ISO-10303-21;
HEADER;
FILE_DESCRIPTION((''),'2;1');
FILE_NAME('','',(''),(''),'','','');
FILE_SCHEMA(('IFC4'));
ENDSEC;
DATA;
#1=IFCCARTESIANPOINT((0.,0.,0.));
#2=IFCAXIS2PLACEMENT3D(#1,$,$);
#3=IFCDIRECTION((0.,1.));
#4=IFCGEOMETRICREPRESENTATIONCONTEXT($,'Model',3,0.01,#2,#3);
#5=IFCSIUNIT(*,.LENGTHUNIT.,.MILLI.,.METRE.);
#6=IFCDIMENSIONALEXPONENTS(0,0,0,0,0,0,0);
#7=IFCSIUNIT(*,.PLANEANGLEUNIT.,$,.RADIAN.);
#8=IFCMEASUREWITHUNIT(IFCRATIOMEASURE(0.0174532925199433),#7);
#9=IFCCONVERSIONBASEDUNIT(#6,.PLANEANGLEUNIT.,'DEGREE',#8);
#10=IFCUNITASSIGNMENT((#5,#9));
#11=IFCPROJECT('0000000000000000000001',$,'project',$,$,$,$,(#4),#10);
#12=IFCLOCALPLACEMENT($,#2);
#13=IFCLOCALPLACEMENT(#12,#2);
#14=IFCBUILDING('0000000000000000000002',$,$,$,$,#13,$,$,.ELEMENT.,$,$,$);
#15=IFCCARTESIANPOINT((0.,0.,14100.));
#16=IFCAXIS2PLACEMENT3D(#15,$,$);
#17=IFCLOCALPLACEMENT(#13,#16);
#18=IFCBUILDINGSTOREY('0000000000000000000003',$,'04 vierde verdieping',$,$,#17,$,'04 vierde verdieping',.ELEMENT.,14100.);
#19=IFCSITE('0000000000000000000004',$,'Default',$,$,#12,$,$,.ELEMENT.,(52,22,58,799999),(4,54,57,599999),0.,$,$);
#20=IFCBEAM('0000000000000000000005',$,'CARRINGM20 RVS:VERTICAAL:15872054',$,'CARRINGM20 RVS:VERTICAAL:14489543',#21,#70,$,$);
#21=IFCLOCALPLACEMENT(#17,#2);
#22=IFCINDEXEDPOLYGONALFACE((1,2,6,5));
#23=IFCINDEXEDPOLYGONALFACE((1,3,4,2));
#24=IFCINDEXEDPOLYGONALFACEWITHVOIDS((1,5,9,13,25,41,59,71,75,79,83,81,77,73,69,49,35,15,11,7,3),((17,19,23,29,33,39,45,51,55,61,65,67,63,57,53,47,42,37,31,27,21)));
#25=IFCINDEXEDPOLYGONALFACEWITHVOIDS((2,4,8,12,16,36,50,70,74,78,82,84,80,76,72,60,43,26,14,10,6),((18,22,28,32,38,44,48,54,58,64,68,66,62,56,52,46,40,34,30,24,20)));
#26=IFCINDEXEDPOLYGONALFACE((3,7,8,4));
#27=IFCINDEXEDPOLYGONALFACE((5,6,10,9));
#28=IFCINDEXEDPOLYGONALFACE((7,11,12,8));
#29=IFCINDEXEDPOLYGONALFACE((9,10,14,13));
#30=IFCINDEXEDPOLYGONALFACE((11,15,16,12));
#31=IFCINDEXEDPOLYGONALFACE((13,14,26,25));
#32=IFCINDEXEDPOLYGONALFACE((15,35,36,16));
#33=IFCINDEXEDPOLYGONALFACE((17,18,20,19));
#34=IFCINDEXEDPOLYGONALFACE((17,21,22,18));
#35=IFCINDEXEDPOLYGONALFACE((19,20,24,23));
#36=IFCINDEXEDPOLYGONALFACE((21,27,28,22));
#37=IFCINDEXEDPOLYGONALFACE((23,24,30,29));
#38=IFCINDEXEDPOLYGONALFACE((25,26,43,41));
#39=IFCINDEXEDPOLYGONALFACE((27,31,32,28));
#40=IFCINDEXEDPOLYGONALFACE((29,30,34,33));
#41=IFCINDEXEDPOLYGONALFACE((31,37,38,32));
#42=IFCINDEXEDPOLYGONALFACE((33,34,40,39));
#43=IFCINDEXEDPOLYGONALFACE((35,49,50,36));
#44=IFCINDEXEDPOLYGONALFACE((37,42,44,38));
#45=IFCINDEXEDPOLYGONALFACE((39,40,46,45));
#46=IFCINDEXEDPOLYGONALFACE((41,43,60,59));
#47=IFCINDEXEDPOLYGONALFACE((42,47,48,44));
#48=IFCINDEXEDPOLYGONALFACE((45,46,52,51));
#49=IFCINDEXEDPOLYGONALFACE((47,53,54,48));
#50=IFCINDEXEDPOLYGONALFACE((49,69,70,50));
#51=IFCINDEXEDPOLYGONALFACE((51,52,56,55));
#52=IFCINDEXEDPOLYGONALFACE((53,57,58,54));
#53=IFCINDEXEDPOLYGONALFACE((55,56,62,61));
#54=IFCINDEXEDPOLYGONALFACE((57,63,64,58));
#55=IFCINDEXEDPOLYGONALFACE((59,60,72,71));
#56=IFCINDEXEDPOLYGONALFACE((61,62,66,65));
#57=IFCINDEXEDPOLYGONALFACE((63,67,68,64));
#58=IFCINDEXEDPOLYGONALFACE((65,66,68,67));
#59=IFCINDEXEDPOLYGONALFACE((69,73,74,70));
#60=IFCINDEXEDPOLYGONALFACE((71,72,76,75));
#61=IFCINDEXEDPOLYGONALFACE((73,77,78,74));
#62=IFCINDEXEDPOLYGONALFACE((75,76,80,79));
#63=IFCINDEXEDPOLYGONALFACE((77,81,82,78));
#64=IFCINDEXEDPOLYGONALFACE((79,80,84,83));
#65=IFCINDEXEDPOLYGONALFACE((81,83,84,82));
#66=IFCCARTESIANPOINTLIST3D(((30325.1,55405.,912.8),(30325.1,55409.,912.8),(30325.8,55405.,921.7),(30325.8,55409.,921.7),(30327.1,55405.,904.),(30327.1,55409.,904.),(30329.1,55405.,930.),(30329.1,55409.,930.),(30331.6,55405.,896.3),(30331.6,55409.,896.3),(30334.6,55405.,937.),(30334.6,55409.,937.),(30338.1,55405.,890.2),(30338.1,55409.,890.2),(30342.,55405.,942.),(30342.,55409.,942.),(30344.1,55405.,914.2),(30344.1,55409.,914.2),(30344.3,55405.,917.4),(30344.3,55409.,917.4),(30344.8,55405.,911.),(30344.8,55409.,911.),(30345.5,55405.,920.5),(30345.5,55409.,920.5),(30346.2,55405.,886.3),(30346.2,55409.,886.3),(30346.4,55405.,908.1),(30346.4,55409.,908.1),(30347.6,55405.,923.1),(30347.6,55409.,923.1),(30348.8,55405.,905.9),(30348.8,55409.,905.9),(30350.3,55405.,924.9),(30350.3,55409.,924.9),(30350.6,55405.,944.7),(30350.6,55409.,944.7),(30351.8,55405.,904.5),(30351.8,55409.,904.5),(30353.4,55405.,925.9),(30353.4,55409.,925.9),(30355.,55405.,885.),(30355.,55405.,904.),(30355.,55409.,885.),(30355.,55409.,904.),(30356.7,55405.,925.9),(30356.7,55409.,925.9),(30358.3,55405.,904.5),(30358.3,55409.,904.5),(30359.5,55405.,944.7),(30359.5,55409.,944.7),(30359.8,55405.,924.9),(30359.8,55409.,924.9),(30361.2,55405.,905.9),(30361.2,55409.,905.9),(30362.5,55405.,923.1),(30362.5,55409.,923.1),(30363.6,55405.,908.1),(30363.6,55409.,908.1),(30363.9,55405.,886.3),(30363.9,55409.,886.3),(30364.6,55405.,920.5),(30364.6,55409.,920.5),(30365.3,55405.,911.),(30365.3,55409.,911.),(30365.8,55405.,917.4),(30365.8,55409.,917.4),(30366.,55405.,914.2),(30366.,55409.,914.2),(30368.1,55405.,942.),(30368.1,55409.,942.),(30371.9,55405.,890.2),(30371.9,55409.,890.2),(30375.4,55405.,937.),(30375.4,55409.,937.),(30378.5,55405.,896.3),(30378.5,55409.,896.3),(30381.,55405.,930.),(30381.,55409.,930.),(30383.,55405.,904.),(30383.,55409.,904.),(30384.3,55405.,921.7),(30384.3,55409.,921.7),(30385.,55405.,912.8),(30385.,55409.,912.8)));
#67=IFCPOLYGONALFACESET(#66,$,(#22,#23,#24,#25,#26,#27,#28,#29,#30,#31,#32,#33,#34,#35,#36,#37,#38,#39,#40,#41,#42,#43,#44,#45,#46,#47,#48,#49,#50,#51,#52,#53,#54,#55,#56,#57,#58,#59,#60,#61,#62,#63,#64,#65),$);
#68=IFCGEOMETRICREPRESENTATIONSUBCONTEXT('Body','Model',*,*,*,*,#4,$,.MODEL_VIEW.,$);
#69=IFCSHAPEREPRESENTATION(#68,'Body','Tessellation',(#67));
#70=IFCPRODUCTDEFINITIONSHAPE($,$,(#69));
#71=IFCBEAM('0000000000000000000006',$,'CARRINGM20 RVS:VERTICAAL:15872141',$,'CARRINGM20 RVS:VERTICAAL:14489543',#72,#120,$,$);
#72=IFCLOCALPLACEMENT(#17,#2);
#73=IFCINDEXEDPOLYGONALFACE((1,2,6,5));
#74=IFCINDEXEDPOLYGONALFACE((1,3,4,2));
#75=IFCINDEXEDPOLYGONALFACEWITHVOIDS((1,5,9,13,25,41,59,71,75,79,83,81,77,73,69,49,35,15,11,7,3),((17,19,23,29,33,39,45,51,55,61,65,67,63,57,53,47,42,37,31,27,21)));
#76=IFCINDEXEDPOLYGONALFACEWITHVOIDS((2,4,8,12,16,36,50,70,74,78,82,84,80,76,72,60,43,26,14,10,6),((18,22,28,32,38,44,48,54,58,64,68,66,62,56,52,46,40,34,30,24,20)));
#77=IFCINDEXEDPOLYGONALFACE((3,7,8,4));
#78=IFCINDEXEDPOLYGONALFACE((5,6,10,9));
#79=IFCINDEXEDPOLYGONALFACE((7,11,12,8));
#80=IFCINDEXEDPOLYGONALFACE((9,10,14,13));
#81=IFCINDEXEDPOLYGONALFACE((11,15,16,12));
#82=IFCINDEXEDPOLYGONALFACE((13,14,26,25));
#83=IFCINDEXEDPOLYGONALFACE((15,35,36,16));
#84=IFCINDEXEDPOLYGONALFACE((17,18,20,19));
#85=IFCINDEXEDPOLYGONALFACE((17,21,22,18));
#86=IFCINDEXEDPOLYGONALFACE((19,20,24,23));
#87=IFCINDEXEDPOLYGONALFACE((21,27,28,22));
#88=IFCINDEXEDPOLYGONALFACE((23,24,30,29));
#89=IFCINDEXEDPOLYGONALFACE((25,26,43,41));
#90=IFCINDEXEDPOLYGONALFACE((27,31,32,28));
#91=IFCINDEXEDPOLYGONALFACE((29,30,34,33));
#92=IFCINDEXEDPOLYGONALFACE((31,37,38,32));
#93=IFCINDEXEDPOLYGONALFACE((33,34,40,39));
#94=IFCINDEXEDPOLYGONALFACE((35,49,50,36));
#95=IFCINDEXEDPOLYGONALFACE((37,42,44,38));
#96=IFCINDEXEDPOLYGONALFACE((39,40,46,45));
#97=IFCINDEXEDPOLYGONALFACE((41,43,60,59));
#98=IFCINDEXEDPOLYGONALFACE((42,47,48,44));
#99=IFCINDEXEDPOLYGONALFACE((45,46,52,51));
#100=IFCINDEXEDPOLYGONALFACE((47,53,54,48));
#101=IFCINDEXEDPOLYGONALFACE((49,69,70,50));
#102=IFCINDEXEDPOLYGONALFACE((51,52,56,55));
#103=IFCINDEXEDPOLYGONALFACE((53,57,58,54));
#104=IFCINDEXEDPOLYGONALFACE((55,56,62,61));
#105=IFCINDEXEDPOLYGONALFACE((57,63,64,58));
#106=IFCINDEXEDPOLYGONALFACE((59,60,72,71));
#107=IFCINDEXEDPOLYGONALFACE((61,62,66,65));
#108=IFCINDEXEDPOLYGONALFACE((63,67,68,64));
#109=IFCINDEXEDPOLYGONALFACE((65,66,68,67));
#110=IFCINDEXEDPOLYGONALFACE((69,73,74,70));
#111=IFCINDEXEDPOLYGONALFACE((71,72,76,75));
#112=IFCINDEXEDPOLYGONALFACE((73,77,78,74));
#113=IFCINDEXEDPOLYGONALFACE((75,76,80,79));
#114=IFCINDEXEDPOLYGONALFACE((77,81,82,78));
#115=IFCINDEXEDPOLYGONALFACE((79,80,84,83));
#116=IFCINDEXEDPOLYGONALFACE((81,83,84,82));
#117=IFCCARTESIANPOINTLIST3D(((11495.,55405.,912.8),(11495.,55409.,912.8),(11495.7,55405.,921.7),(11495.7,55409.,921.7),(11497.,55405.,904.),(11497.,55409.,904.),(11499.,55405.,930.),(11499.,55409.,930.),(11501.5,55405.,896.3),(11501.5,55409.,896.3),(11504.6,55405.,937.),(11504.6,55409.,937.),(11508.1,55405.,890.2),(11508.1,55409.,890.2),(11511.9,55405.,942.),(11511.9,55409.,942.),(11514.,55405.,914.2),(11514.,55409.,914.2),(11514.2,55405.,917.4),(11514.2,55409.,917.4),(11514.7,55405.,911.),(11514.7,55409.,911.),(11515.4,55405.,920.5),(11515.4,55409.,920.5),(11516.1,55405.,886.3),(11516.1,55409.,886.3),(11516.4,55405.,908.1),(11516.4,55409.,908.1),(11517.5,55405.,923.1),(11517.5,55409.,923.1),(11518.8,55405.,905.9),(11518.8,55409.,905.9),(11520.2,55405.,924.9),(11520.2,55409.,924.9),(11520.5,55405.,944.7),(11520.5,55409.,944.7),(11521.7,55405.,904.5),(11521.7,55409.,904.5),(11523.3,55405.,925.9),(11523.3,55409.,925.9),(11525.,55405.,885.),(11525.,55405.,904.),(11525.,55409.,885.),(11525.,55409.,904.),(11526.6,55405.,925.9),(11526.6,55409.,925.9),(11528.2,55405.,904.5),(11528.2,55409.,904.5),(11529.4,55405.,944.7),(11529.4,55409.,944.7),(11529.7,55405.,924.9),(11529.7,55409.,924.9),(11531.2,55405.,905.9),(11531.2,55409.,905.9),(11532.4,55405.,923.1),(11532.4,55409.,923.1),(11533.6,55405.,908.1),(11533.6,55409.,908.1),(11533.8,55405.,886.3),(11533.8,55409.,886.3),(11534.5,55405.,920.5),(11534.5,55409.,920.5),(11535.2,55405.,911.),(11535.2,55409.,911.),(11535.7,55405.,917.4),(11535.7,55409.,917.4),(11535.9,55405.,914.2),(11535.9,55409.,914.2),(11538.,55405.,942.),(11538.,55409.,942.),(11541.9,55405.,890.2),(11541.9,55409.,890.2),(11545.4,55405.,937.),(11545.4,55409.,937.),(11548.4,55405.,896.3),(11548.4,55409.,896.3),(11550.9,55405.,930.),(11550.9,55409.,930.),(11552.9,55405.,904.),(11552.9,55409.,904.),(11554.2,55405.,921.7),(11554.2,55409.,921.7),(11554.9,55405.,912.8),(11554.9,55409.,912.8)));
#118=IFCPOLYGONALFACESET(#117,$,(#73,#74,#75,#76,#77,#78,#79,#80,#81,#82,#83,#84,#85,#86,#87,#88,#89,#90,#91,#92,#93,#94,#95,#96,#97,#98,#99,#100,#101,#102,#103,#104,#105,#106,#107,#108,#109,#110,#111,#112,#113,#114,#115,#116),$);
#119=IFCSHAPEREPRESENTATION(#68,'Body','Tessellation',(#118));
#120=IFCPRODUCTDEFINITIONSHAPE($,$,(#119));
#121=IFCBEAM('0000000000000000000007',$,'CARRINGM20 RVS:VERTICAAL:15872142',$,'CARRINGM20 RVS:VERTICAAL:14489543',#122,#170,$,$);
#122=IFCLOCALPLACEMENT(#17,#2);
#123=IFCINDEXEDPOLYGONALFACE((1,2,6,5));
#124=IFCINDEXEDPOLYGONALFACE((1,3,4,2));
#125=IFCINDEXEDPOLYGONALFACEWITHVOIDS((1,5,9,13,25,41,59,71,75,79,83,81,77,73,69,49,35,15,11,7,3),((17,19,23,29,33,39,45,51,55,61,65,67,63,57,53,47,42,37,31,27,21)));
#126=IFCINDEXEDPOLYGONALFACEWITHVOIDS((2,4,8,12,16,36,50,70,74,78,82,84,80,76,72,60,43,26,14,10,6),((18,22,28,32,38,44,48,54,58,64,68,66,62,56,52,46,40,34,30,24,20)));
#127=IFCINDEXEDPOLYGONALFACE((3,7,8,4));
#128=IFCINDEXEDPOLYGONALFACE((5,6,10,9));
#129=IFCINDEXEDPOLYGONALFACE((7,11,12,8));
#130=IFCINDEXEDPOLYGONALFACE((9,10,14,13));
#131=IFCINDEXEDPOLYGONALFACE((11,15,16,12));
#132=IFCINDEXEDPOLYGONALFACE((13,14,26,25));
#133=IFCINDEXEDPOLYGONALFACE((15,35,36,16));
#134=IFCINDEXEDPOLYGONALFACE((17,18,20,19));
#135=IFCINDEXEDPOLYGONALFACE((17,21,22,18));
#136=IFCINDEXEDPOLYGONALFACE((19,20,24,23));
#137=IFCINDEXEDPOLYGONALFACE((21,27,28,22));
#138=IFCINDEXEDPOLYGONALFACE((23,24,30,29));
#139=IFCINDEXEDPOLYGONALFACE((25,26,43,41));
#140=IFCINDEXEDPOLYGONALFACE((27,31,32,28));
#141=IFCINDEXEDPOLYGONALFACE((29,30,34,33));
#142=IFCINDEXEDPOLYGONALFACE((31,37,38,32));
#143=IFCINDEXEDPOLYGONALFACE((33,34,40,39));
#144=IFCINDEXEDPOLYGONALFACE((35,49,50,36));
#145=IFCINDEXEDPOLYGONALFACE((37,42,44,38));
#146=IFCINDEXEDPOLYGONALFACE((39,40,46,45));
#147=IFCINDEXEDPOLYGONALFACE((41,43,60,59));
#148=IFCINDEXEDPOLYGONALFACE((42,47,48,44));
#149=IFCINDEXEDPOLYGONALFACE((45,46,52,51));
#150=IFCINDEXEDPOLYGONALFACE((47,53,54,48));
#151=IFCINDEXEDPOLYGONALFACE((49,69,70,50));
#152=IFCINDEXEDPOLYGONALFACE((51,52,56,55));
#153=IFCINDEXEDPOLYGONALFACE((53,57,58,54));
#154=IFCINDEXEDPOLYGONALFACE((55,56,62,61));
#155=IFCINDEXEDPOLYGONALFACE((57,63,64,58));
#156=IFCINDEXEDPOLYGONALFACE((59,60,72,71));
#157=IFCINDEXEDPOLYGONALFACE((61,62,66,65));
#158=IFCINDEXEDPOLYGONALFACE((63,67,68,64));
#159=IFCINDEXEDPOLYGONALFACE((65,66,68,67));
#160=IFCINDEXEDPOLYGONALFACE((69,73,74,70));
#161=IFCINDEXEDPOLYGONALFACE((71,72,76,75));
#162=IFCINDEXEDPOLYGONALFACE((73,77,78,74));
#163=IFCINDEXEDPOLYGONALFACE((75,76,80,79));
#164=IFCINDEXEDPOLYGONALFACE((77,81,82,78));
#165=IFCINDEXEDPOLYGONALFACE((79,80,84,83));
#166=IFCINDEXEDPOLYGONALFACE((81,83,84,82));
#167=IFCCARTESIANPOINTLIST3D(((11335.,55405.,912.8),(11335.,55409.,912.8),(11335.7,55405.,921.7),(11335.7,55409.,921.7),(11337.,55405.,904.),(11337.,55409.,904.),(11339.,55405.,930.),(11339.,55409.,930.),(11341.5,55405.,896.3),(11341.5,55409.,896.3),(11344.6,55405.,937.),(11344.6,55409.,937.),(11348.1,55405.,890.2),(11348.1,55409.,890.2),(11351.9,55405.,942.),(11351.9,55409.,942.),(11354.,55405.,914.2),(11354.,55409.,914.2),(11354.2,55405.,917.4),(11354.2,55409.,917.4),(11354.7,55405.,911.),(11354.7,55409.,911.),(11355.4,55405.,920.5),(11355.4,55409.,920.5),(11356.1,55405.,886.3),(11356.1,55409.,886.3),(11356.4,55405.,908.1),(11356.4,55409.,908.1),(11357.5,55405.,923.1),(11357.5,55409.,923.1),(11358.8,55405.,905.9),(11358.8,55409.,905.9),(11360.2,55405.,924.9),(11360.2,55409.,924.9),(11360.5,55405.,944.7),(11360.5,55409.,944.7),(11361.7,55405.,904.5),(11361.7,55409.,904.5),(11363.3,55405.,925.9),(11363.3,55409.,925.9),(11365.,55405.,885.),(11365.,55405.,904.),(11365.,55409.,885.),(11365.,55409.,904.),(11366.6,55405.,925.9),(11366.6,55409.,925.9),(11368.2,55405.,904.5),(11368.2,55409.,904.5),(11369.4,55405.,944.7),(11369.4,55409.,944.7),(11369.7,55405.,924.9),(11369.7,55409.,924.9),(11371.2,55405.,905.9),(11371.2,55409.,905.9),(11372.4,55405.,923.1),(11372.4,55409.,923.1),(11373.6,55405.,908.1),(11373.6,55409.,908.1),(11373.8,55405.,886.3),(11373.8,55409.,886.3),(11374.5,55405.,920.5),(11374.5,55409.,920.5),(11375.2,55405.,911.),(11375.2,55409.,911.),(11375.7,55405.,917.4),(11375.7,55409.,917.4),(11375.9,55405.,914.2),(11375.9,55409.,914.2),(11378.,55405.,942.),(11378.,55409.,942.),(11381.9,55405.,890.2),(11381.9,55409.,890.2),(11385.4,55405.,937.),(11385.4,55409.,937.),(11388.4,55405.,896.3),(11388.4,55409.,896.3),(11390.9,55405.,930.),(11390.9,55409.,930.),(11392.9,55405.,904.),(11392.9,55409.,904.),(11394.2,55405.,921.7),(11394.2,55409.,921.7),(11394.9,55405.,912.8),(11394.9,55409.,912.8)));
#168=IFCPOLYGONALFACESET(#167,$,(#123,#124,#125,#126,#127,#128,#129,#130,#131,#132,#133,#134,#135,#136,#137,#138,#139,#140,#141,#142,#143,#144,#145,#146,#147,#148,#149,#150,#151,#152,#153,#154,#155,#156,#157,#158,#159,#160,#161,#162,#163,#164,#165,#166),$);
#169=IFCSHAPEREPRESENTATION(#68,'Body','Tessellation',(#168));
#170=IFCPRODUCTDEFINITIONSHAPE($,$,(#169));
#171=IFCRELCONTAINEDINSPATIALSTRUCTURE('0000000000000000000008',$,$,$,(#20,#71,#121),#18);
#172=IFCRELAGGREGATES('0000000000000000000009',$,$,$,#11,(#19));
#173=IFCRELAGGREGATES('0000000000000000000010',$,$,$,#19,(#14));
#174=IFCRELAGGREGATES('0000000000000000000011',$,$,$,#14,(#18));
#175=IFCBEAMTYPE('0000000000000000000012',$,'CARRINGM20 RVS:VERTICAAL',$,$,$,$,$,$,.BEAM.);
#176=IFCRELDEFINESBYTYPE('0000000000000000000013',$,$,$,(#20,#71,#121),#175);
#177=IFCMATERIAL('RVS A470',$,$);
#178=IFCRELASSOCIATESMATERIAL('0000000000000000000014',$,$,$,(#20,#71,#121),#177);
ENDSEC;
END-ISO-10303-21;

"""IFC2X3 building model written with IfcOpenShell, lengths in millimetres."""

from ifc_helpers import new_model, entity, si_unit, converted_unit, direction, frame, origin, origin_2d_with_axis, place, context, subcontext, project, spatial, hollow_circle, extrude, material, type_object, element, save


model = new_model("IFC2X3")

# Units and contexts
model_context = context("Model", 3, precision=0.01, world=origin(), true_north=direction((0.0, 1.0)))
body_context = subcontext(model_context, "Body", "Model", "MODEL_VIEW")
ifc_project = project(units=[si_unit("LENGTHUNIT", "METRE", prefix="MILLI"), converted_unit("PLANEANGLEUNIT", "DEGREE", entity("IfcRatioMeasure", 0.0174532925199433), si_unit("PLANEANGLEUNIT", "RADIAN"), dimensions=[0, 0, 0, 0, 0, 0, 0])], contexts=[model_context])

# Site, building, storey
site_placement = place(None, origin())
site = spatial("IfcSite", under=ifc_project, at=site_placement, Name="Default", CompositionType="ELEMENT", RefLatitude=(52, 22, 58, 799999), RefLongitude=(4, 54, 57, 599999), RefElevation=0.0)
building_placement = place(site_placement, origin())
building = spatial("IfcBuilding", under=site, at=building_placement, CompositionType="ELEMENT")
storey_placement = place(building_placement, frame((0.0, 0.0, 14100.0)))
storey = spatial("IfcBuildingStorey", under=building, at=storey_placement, Name="04 vierde verdieping", LongName="04 vierde verdieping", CompositionType="ELEMENT", Elevation=14100.0)

# Beams
ifc_material_1 = material(Name="RVS A470")
beam_type_1 = type_object("IfcBeamType", Name="CARRINGM20 RVS:VERTICAAL", PredefinedType="BEAM")
beam_1_placement = place(storey_placement, origin())
element("IfcBeam", 1, at=beam_1_placement, inside=storey, type_object=beam_type_1, material=ifc_material_1, Name="CARRINGM20 RVS:VERTICAAL:15872054", ObjectType="CARRINGM20 RVS:VERTICAAL:14489543", context=body_context, shape_type="SweptSolid", body=[
    extrude(hollow_circle(Radius=30.0, WallThickness=19.0, at=origin_2d_with_axis()), frame((30355.0, 55405.0, 915.0), z_axis=(0.0, 1.0, 0.0), x_axis=(0.0, 0.0, -1.0)), (0.0, 0.0, 1.0), 4.0),
])
beam_2_placement = place(storey_placement, origin())
element("IfcBeam", 2, at=beam_2_placement, inside=storey, type_object=beam_type_1, material=ifc_material_1, Name="CARRINGM20 RVS:VERTICAAL:15872141", ObjectType="CARRINGM20 RVS:VERTICAAL:14489543", context=body_context, shape_type="SweptSolid", body=[
    extrude(hollow_circle(Radius=30.0, WallThickness=19.0, at=origin_2d_with_axis()), frame((11525.0, 55405.0, 915.0), z_axis=(0.0, 1.0, 0.0), x_axis=(0.0, 0.0, -1.0)), (0.0, 0.0, 1.0), 4.0),
])
beam_3_placement = place(storey_placement, origin())
element("IfcBeam", 3, at=beam_3_placement, inside=storey, type_object=beam_type_1, material=ifc_material_1, Name="CARRINGM20 RVS:VERTICAAL:15872142", ObjectType="CARRINGM20 RVS:VERTICAAL:14489543", context=body_context, shape_type="SweptSolid", body=[
    extrude(hollow_circle(Radius=30.0, WallThickness=19.0, at=origin_2d_with_axis()), frame((11365.0, 55405.0, 915.0), z_axis=(0.0, 1.0, 0.0), x_axis=(0.0, 0.0, -1.0)), (0.0, 0.0, 1.0), 4.0),
])

save(model, "model.ifc")
